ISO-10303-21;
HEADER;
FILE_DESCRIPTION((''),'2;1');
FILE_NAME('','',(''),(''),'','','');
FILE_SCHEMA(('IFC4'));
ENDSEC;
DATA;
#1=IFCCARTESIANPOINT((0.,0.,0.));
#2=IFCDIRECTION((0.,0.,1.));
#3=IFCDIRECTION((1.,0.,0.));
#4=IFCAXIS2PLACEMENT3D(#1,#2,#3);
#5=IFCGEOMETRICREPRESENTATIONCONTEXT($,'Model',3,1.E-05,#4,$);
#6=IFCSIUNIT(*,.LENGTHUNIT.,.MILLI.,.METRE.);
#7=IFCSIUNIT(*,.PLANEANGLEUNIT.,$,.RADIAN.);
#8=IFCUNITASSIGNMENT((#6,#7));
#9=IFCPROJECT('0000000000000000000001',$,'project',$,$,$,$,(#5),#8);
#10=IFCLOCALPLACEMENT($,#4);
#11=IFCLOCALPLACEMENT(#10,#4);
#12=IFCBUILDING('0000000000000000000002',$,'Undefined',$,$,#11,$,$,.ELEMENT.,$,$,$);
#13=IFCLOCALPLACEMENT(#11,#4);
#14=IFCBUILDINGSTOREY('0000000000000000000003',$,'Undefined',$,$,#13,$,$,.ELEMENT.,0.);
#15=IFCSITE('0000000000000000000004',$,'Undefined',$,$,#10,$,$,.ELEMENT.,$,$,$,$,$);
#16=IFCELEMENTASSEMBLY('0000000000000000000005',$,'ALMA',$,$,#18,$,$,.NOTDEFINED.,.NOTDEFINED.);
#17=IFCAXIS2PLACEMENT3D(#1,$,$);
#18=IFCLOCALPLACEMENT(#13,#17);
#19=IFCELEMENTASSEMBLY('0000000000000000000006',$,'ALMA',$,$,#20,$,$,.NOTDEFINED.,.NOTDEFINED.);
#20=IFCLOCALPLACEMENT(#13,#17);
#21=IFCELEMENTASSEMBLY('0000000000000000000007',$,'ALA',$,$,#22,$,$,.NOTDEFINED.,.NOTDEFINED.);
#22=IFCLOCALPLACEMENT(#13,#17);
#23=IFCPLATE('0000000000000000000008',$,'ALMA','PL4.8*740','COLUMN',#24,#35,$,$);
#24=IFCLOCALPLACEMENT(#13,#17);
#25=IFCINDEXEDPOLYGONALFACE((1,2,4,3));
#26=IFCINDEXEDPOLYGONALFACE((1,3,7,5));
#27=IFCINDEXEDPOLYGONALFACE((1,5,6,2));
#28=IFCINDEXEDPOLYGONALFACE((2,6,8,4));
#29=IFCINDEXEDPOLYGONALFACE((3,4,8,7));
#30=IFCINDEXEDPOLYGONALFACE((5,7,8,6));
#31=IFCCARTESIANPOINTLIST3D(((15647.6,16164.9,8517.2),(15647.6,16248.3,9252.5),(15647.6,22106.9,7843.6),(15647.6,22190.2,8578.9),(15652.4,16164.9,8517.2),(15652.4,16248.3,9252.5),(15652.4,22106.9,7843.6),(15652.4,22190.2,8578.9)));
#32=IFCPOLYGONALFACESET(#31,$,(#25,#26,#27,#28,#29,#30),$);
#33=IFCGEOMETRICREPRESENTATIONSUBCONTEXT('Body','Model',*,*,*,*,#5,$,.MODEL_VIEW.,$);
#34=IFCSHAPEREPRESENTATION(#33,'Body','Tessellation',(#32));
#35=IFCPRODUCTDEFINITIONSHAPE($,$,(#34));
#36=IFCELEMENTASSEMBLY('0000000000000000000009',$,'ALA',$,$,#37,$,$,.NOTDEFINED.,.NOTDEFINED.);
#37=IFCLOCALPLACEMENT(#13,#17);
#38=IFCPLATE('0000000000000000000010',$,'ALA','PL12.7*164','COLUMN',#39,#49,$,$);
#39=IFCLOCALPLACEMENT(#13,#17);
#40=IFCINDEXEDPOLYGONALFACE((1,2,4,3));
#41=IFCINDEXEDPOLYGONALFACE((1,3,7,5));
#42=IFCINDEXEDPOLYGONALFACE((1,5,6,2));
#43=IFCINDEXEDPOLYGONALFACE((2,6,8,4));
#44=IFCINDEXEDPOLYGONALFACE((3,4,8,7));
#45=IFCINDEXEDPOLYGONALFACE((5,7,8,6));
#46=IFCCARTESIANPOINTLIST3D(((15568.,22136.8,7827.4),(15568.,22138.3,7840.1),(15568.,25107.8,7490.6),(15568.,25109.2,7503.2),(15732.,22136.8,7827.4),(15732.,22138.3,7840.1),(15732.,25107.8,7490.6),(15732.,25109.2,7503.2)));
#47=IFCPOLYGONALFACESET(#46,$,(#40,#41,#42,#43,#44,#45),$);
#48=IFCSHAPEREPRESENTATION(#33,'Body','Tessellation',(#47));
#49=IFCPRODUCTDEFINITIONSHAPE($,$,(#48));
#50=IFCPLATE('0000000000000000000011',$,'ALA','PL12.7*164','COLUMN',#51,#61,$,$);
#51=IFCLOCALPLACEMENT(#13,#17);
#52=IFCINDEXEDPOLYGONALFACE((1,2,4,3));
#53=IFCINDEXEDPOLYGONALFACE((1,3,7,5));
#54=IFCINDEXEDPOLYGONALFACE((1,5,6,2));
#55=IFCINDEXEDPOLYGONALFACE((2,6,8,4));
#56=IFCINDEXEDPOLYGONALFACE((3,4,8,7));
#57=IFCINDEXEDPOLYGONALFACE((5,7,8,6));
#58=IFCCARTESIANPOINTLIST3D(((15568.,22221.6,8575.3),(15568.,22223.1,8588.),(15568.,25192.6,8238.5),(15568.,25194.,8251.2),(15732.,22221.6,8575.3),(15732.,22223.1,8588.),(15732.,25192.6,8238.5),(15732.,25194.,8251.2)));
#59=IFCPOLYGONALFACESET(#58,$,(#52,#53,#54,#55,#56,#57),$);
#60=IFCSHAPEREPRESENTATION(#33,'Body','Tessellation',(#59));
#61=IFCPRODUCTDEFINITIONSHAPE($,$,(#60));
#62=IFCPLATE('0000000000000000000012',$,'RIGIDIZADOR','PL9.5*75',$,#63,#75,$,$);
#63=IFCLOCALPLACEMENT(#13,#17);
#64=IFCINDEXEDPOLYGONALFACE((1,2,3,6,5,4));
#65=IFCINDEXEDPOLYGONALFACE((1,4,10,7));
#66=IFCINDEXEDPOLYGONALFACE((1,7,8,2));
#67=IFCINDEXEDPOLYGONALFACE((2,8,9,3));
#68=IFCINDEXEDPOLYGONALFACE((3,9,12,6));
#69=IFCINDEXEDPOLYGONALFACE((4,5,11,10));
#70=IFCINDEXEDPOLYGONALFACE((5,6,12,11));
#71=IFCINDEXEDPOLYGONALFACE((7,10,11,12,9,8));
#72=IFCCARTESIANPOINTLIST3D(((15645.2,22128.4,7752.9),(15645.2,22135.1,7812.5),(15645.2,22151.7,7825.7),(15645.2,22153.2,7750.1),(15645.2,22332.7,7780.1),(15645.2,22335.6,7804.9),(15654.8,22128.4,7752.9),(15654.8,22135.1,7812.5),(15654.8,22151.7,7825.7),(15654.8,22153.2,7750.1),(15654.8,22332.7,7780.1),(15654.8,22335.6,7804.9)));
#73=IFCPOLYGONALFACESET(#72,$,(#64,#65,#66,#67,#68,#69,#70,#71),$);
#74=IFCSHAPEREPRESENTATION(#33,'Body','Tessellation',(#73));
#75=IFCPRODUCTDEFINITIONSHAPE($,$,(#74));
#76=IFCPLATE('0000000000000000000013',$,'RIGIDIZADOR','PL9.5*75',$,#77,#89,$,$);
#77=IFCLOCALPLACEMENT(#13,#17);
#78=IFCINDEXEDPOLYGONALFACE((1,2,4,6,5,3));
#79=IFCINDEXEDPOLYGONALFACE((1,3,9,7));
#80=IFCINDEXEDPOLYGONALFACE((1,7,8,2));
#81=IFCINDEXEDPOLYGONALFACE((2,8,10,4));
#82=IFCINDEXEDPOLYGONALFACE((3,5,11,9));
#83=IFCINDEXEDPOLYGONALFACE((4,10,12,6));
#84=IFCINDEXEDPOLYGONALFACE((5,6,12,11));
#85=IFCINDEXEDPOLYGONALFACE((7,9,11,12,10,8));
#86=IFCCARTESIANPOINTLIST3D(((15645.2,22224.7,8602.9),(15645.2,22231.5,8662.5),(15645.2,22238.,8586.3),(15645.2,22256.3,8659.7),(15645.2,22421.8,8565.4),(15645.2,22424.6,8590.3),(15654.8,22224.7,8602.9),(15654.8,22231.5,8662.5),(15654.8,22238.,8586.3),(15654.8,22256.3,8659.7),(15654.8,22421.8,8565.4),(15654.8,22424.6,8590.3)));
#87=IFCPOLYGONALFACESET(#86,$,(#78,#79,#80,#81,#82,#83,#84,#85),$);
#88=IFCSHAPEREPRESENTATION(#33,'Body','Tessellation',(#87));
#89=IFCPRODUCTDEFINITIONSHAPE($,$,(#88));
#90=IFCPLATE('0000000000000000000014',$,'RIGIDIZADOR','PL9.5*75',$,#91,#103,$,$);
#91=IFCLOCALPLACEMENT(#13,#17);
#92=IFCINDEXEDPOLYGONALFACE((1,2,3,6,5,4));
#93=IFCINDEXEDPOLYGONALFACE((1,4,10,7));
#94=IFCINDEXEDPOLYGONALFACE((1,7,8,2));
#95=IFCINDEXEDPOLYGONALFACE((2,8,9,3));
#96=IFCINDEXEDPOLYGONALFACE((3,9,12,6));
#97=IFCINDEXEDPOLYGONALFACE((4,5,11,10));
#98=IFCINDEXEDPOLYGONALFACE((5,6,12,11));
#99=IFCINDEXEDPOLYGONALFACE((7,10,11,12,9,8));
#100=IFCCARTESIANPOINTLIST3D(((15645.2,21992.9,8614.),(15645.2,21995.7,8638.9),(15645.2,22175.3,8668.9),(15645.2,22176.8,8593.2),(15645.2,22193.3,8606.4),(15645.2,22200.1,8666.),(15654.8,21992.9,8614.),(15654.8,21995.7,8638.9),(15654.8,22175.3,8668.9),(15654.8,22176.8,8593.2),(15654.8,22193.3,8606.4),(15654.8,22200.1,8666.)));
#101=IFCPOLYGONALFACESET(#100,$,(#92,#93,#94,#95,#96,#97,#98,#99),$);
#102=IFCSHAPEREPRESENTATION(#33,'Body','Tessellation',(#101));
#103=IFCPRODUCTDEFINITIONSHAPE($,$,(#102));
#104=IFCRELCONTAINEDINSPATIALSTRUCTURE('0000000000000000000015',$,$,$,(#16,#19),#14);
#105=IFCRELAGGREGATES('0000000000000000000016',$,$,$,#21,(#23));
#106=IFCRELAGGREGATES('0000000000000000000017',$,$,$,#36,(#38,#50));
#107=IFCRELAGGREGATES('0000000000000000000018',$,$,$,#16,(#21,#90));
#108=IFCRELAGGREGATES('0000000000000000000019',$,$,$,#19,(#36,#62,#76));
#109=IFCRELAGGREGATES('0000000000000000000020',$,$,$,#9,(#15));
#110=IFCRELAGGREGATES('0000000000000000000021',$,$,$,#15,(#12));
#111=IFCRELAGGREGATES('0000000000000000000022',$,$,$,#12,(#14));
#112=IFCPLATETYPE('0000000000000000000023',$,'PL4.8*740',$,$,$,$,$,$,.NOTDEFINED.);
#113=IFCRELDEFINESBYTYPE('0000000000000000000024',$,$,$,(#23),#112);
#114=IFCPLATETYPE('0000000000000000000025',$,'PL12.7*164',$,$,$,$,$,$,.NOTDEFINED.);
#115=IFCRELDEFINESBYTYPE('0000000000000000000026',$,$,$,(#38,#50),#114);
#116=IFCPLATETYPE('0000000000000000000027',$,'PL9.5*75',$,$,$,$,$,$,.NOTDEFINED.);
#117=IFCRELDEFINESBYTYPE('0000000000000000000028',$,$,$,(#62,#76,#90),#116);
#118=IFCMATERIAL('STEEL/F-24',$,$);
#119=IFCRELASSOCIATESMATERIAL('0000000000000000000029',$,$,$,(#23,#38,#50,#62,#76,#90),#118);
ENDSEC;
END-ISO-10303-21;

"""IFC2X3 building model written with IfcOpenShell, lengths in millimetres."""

from ifc_helpers import new_model, si_unit, frame, origin_with_axes, place, context, subcontext, project, spatial, polyline, outline, extrude, material, type_object, element, aggregate, save


model = new_model("IFC2X3")

# Units and contexts
model_context = context("Model", 3, precision=1e-05, world=origin_with_axes())
body_context = subcontext(model_context, "Body", "Model", "MODEL_VIEW")
ifc_project = project(units=[si_unit("LENGTHUNIT", "METRE", prefix="MILLI"), si_unit("PLANEANGLEUNIT", "RADIAN")], contexts=[model_context])

# Site, building, storey
site_placement = place(None, origin_with_axes())
site = spatial("IfcSite", under=ifc_project, at=site_placement, Name="Undefined", CompositionType="ELEMENT")
building_placement = place(site_placement, origin_with_axes())
building = spatial("IfcBuilding", under=site, at=building_placement, Name="Undefined", CompositionType="ELEMENT")
storey_placement = place(building_placement, origin_with_axes())
storey = spatial("IfcBuildingStorey", under=building, at=storey_placement, Name="Undefined", CompositionType="ELEMENT", Elevation=0.0)

# Shared definitions
ifc_material_1 = material(Name="STEEL/F-24")

# Element assembly
assembly_1_placement = place(storey_placement, origin_with_axes())
assembly_1 = element("IfcElementAssembly", 1, at=assembly_1_placement, inside=storey, Name="ALMA", AssemblyPlace="NOTDEFINED", PredefinedType="NOTDEFINED")

# Element assembly
assembly_2_placement = place(storey_placement, origin_with_axes())
assembly_2 = element("IfcElementAssembly", 2, at=assembly_2_placement, inside=storey, Name="ALMA", AssemblyPlace="NOTDEFINED", PredefinedType="NOTDEFINED")

# Element assembly, plate
assembly_3_placement = place(assembly_1_placement, origin_with_axes())
assembly_3 = element("IfcElementAssembly", 3, at=assembly_3_placement, Name="ALA", AssemblyPlace="NOTDEFINED", PredefinedType="NOTDEFINED")
plate_type_1 = type_object("IfcPlateType", Name="PL4.8*740", PredefinedType="NOTDEFINED")
plate_1_placement = place(assembly_3_placement, frame((15650.0, 22148.5, 8211.3), z_axis=(-1.0, 0.0, 0.0), x_axis=(0.0, -0.993635, 0.112644)))
plate_1 = element("IfcPlate", 4, at=plate_1_placement, type_object=plate_type_1, material=ifc_material_1, Name="ALMA", Description="PL4.8*740", ObjectType="COLUMN", context=body_context, shape_type="SweptSolid", body=[
    extrude(outline(polyline([(0.0, -370.0), (0.0, 370.0), (5980.0, 370.0), (5980.0, -370.0), (0.0, -370.0)])), frame((0.0, 0.0, -2.4), z_axis=(0.0, 0.0, 1.0), x_axis=(1.0, 0.0, 0.0)), (0.0, 0.0, 1.0), 4.8),
])
aggregate(assembly_3, [plate_1])

# Element assembly, plates
assembly_4_placement = place(assembly_2_placement, origin_with_axes())
assembly_4 = element("IfcElementAssembly", 5, at=assembly_4_placement, Name="ALA", AssemblyPlace="NOTDEFINED", PredefinedType="NOTDEFINED")
plate_type_2 = type_object("IfcPlateType", Name="PL12.7*164", PredefinedType="NOTDEFINED")
plate_2_placement = place(assembly_4_placement, frame((15650.0, 22137.6, 7833.7), z_axis=(0.0, -0.112644, -0.993635), x_axis=(0.0, 0.993635, -0.112644)))
plate_2 = element("IfcPlate", 6, at=plate_2_placement, type_object=plate_type_2, material=ifc_material_1, Name="ALA", Description="PL12.7*164", ObjectType="COLUMN", context=body_context, shape_type="SweptSolid", body=[
    extrude(outline(polyline([(0.0, -82.0), (0.0, 82.0), (2990.0, 82.0), (2990.0, -82.0), (0.0, -82.0)])), frame((0.0, 0.0, -6.3), z_axis=(0.0, 0.0, 1.0), x_axis=(1.0, 0.0, 0.0)), (0.0, 0.0, 1.0), 12.7),
])
plate_3_placement = place(assembly_4_placement, frame((15650.0, 22222.3, 8581.6), z_axis=(0.0, -0.112644, -0.993635), x_axis=(0.0, 0.993635, -0.112644)))
plate_3 = element("IfcPlate", 7, at=plate_3_placement, type_object=plate_type_2, material=ifc_material_1, Name="ALA", Description="PL12.7*164", ObjectType="COLUMN", context=body_context, shape_type="SweptSolid", body=[
    extrude(outline(polyline([(0.0, -82.0), (0.0, 82.0), (2990.0, 82.0), (2990.0, -82.0), (0.0, -82.0)])), frame((0.0, 0.0, -6.3), z_axis=(0.0, 0.0, 1.0), x_axis=(1.0, 0.0, 0.0)), (0.0, 0.0, 1.0), 12.7),
])
aggregate(assembly_4, [plate_2, plate_3])

# Plates
plate_type_3 = type_object("IfcPlateType", Name="PL9.5*75", PredefinedType="NOTDEFINED")
plate_4_placement = place(assembly_2_placement, frame((15650.0, 22136.8, 7827.4), z_axis=(-1.0, 0.0, 0.0), x_axis=(0.0, 0.993635, -0.112644)))
plate_4 = element("IfcPlate", 8, at=plate_4_placement, type_object=plate_type_3, material=ifc_material_1, Name="RIGIDIZADOR", Description="PL9.5*75", context=body_context, shape_type="SweptSolid", body=[
    extrude(outline(polyline([(0.0, 15.0), (15.0, 0.0), (200.0, 0.0), (200.0, 25.0), (25.0, 75.0), (0.0, 75.0), (0.0, 15.0)])), frame((0.0, 0.0, -4.8), z_axis=(0.0, 0.0, 1.0), x_axis=(1.0, 0.0, 0.0)), (0.0, 0.0, 1.0), 9.5),
])
plate_5_placement = place(assembly_2_placement, frame((15650.0, 22223.1, 8588.0), z_axis=(1.0, 0.0, 0.0), x_axis=(0.0, 0.993635, -0.112644)))
plate_5 = element("IfcPlate", 9, at=plate_5_placement, type_object=plate_type_3, material=ifc_material_1, Name="RIGIDIZADOR", Description="PL9.5*75", context=body_context, shape_type="SweptSolid", body=[
    extrude(outline(polyline([(0.0, 15.0), (15.0, 0.0), (200.0, 0.0), (200.0, 25.0), (25.0, 75.0), (0.0, 75.0), (0.0, 15.0)])), frame((0.0, 0.0, -4.8), z_axis=(0.0, 0.0, 1.0), x_axis=(1.0, 0.0, 0.0)), (0.0, 0.0, 1.0), 9.5),
])
plate_6_placement = place(assembly_1_placement, frame((15650.0, 22191.7, 8591.5), z_axis=(-1.0, 0.0, 0.0), x_axis=(0.0, -0.993635, 0.112644)))
plate_6 = element("IfcPlate", 10, at=plate_6_placement, type_object=plate_type_3, material=ifc_material_1, Name="RIGIDIZADOR", Description="PL9.5*75", context=body_context, shape_type="SweptSolid", body=[
    extrude(outline(polyline([(0.0, 15.0), (15.0, 0.0), (200.0, 0.0), (200.0, 25.0), (25.0, 75.0), (0.0, 75.0), (0.0, 15.0)])), frame((0.0, 0.0, -4.8), z_axis=(0.0, 0.0, 1.0), x_axis=(1.0, 0.0, 0.0)), (0.0, 0.0, 1.0), 9.5),
])

aggregate(assembly_1, [assembly_3, plate_6])

aggregate(assembly_2, [assembly_4, plate_4, plate_5])

save(model, "model.ifc")
